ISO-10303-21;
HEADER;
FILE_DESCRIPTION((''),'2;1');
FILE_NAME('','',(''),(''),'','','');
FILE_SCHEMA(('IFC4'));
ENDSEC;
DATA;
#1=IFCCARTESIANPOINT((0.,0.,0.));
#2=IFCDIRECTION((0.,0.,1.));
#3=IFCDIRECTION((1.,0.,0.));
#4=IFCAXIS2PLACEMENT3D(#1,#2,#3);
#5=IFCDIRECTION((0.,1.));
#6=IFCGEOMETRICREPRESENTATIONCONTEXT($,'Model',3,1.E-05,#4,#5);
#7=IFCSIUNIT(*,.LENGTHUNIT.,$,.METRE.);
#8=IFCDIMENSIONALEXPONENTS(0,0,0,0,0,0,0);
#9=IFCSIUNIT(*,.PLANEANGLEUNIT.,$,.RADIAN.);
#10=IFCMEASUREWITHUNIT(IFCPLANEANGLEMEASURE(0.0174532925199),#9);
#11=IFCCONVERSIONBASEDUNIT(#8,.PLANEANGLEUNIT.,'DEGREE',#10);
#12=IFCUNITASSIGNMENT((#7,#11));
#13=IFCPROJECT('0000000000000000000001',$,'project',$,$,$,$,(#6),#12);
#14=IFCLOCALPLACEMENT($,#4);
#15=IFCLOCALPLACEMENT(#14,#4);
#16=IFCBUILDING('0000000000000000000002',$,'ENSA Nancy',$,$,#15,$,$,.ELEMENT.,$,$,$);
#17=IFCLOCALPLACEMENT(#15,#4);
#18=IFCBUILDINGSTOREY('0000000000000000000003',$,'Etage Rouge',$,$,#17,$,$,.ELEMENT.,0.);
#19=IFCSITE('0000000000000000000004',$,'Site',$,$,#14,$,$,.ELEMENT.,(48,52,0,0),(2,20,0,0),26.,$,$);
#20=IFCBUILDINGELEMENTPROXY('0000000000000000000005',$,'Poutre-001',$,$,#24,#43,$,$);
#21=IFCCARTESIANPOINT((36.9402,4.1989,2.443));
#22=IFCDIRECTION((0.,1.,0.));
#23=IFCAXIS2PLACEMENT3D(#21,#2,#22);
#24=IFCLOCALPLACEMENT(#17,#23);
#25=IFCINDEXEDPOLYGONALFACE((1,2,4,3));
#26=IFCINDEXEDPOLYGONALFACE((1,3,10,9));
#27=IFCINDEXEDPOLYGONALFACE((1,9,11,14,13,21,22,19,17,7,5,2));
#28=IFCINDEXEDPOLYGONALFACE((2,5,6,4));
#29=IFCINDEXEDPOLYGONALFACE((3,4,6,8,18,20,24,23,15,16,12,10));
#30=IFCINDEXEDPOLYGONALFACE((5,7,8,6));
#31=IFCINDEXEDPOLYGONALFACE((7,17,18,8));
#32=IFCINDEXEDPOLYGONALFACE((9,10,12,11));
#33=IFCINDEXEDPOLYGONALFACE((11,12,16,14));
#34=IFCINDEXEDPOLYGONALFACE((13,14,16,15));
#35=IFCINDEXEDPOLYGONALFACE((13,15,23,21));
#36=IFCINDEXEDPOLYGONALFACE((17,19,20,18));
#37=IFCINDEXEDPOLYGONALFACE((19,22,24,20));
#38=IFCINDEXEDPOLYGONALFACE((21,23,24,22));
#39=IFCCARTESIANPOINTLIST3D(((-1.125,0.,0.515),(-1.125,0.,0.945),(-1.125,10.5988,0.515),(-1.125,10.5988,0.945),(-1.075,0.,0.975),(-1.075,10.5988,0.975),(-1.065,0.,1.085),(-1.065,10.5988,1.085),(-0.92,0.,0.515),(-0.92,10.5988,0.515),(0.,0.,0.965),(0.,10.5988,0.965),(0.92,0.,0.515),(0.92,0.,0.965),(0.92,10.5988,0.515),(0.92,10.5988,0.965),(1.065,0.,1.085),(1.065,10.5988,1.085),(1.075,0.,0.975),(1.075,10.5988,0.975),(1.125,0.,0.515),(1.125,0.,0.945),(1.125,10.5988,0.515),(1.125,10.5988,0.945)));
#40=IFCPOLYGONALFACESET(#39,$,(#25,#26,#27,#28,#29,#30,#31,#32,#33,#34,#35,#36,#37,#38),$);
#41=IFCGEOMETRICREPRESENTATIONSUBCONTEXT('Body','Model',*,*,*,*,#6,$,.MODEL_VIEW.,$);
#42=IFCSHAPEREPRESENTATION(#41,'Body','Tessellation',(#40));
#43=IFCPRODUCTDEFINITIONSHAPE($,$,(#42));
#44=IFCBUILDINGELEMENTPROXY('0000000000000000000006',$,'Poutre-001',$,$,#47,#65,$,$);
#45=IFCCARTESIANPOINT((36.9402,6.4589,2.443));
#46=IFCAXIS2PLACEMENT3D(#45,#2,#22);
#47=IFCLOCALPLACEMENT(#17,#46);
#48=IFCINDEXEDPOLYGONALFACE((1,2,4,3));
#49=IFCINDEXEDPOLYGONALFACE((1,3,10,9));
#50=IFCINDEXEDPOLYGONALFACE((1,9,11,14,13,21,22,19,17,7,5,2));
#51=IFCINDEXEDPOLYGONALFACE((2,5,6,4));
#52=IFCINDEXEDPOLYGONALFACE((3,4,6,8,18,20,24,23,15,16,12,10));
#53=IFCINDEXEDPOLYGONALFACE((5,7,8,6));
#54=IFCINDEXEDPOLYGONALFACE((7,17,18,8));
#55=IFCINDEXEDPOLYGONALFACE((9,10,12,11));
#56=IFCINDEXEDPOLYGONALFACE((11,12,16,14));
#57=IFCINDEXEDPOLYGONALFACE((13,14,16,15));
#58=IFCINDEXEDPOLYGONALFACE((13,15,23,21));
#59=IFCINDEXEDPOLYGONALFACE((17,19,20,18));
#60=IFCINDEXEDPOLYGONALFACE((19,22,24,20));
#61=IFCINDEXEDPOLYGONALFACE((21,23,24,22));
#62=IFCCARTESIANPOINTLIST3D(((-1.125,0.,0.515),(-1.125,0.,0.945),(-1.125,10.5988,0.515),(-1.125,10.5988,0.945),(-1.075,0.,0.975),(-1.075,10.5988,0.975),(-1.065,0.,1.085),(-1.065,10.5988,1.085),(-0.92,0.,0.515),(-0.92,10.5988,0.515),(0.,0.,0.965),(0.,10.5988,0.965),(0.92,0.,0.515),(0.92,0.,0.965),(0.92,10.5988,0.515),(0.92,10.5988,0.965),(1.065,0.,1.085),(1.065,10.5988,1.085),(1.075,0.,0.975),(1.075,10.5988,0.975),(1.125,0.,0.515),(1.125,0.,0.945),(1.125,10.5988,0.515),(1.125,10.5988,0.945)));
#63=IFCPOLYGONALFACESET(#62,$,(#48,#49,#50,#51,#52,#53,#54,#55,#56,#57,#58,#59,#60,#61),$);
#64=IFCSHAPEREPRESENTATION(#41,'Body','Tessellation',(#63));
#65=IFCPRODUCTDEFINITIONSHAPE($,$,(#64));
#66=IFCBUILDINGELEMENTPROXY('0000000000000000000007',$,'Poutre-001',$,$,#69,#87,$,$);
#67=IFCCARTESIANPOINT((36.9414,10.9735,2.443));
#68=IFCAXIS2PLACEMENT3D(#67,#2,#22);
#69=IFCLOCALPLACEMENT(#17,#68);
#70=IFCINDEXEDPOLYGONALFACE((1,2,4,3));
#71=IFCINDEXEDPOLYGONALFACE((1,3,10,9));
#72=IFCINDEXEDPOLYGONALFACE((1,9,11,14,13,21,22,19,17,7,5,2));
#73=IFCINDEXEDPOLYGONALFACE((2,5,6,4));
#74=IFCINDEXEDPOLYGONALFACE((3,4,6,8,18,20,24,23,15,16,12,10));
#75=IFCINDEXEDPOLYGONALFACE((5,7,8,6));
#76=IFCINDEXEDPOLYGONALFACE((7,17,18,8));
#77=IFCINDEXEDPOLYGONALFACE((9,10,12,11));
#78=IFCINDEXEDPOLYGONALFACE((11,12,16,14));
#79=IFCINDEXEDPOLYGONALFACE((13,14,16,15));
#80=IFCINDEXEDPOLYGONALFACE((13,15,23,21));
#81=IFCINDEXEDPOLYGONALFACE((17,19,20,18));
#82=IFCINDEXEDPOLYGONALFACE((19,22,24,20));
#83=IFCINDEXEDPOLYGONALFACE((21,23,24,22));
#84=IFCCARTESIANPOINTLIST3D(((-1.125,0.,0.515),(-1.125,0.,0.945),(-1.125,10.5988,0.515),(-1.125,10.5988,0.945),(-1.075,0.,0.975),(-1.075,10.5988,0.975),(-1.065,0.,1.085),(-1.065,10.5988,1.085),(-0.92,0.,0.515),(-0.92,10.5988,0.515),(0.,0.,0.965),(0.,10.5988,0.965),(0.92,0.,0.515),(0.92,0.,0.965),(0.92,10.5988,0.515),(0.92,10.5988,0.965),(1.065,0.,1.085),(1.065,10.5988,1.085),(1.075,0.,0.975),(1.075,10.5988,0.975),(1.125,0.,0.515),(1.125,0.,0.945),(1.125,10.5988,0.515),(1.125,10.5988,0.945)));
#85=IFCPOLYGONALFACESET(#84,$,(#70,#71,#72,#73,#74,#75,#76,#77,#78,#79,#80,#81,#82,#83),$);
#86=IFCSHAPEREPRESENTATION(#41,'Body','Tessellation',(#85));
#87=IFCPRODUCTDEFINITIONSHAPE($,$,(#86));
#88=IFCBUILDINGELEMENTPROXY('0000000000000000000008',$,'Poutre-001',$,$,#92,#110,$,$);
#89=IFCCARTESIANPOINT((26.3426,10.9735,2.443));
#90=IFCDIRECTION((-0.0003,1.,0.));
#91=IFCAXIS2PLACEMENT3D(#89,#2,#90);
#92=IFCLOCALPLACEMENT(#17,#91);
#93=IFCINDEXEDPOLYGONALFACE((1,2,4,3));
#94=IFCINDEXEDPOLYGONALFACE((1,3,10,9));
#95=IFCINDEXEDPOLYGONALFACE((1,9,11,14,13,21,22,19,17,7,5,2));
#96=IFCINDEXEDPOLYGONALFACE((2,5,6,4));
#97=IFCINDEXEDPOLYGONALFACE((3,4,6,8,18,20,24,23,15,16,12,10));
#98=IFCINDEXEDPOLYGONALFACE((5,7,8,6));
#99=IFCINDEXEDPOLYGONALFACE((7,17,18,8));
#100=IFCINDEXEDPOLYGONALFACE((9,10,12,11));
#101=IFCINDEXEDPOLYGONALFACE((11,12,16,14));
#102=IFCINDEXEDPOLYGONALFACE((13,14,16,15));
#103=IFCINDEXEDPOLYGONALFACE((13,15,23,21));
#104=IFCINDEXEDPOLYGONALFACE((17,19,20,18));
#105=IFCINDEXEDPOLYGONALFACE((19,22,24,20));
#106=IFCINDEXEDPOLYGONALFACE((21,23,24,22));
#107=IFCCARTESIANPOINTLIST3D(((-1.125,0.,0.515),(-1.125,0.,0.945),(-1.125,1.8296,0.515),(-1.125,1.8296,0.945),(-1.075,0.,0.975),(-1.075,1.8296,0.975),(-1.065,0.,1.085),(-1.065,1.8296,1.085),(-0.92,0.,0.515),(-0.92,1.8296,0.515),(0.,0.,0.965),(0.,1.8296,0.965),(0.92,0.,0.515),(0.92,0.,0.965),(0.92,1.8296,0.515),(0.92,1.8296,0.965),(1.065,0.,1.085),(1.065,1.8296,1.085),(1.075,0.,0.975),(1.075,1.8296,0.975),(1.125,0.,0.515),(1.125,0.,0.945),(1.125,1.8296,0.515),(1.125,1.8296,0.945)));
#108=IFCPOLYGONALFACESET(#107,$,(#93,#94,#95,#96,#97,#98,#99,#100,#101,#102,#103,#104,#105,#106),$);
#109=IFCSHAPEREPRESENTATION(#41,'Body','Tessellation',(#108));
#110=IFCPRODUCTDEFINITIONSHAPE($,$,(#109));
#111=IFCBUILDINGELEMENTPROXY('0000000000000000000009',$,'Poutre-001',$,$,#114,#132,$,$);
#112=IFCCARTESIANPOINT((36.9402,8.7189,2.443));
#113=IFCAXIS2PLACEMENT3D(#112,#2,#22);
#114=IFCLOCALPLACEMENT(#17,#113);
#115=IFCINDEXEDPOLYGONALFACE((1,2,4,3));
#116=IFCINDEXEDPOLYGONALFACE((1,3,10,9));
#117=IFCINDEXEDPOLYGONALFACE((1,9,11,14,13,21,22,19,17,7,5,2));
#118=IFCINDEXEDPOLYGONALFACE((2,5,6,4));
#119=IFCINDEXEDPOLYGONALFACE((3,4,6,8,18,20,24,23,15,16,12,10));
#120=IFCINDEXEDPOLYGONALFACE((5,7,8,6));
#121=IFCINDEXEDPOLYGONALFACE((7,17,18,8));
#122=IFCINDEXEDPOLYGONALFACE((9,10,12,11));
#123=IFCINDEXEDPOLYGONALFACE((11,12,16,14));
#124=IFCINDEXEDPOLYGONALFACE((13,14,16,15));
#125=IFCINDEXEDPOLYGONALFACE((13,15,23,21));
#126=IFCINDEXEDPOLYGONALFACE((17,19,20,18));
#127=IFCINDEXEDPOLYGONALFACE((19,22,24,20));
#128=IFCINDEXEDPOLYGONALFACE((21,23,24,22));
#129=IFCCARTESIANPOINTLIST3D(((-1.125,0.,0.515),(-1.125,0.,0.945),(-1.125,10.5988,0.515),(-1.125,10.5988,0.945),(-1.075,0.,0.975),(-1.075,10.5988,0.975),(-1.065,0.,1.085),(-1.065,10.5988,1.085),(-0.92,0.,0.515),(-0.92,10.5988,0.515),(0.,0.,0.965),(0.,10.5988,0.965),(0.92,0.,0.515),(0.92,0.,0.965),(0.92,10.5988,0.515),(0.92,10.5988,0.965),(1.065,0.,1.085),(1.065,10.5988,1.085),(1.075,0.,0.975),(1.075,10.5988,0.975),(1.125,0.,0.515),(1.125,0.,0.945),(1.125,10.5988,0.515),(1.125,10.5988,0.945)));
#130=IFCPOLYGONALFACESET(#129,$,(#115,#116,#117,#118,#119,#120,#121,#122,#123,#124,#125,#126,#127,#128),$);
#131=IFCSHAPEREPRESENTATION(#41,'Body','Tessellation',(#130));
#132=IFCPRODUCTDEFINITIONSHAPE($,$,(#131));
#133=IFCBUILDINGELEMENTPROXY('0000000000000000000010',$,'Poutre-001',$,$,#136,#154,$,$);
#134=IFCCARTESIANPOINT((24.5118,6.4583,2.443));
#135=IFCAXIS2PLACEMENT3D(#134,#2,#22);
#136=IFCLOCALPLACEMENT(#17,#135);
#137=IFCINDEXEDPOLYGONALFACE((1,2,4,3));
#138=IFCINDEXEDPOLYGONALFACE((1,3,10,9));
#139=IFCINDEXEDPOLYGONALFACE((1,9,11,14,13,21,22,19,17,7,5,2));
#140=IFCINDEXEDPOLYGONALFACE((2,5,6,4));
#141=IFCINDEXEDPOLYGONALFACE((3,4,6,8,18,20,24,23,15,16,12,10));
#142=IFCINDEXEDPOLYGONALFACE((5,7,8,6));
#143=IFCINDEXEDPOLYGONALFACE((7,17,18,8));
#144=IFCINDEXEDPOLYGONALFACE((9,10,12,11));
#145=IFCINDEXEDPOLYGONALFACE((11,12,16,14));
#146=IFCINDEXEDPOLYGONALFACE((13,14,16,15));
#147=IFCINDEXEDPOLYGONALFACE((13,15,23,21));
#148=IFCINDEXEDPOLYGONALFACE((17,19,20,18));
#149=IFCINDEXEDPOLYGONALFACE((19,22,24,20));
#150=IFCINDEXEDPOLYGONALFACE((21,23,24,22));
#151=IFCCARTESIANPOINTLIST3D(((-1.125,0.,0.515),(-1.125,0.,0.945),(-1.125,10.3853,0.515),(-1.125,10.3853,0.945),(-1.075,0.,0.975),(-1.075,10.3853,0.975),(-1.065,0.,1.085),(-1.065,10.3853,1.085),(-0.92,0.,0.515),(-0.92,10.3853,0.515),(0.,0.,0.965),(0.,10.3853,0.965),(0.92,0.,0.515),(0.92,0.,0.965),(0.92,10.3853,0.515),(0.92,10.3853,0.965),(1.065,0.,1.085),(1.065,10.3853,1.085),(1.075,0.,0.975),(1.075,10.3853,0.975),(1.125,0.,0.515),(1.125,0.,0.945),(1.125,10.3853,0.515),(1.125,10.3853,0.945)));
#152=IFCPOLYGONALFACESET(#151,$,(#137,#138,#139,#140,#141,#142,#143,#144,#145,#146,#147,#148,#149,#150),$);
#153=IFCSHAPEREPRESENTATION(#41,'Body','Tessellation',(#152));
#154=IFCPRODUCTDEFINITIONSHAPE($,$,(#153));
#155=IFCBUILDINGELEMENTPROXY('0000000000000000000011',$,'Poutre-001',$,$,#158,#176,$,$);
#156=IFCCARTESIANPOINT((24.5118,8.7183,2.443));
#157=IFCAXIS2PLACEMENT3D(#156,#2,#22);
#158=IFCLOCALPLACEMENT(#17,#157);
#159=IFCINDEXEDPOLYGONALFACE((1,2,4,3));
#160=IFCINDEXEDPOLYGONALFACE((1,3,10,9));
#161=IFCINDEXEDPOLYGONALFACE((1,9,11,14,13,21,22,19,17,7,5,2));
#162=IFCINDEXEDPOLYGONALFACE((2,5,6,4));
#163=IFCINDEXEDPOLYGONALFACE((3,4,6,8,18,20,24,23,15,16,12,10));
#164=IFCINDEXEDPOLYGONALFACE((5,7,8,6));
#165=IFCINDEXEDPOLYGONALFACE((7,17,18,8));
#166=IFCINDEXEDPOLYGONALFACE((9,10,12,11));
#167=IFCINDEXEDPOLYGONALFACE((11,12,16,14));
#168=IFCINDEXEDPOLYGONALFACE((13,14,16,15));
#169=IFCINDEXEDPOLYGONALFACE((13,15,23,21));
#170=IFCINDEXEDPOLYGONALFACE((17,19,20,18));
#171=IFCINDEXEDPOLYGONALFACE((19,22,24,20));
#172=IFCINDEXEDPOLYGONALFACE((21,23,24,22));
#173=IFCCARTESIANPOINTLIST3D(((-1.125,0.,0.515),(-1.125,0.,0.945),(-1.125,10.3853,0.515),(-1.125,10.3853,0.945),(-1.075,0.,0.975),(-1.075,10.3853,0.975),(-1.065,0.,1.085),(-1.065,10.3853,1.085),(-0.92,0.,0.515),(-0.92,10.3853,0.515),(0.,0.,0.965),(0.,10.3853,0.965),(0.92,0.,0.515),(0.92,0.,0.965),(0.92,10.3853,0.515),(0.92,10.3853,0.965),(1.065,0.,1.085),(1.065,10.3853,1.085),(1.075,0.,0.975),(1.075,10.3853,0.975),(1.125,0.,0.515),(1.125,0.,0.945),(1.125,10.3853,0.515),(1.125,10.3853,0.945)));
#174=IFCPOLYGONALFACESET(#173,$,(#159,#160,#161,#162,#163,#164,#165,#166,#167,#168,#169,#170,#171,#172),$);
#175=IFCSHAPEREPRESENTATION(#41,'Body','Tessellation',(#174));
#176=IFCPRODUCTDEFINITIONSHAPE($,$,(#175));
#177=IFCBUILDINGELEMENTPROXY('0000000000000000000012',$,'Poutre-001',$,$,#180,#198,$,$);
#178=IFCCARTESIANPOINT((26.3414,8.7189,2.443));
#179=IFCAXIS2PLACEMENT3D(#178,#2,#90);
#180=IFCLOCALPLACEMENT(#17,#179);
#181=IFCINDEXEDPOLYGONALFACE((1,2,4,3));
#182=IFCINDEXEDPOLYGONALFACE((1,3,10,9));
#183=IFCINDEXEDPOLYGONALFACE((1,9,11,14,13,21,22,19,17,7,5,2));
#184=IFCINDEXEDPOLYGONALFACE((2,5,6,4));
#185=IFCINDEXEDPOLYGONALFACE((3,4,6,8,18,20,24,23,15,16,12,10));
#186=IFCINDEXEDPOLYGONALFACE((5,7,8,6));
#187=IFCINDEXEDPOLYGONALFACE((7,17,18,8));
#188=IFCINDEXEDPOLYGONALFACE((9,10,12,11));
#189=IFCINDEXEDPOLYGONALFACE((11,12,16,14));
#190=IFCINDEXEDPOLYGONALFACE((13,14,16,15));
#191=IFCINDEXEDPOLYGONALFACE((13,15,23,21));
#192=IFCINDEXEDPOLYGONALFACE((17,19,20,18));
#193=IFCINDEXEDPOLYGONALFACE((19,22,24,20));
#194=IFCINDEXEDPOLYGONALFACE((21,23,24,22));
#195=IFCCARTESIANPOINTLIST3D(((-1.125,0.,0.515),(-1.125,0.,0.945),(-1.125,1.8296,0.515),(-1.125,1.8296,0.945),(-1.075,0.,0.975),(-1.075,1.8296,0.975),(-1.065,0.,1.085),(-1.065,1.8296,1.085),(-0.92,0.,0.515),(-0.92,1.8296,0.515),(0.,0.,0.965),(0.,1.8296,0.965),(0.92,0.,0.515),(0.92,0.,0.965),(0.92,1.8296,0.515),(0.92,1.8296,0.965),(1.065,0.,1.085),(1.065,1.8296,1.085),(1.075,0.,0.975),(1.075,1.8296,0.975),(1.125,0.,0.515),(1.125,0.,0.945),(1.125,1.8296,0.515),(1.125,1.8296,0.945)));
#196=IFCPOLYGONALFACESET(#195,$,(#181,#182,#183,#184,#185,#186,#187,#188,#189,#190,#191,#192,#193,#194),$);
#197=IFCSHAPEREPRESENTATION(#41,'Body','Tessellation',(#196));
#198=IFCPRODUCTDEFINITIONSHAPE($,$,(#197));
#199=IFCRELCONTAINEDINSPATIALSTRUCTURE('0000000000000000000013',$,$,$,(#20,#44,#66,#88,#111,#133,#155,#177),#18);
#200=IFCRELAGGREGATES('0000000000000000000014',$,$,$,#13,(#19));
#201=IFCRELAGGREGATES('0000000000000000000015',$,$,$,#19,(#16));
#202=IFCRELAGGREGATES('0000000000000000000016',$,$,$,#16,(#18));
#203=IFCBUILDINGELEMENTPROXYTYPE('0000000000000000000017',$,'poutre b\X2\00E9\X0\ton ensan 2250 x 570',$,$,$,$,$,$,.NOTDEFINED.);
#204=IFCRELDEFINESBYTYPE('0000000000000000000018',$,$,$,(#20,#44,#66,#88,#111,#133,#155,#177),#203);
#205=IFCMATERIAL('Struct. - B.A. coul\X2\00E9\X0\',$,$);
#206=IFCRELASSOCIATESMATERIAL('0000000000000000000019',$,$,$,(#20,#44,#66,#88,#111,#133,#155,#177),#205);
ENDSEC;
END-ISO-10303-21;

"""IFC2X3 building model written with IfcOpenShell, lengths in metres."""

from ifc_helpers import new_model, entity, si_unit, converted_unit, direction, frame, origin_with_axes, place, context, subcontext, project, spatial, polyline, outline, extrude, material, type_object, element, save


model = new_model("IFC2X3")

# Units and contexts
model_context = context("Model", 3, precision=1e-05, world=origin_with_axes(), true_north=direction((0.0, 1.0)))
body_context = subcontext(model_context, "Body", "Model", "MODEL_VIEW")
ifc_project = project(units=[si_unit("LENGTHUNIT", "METRE"), converted_unit("PLANEANGLEUNIT", "DEGREE", entity("IfcPlaneAngleMeasure", 0.0174532925199), si_unit("PLANEANGLEUNIT", "RADIAN"), dimensions=[0, 0, 0, 0, 0, 0, 0])], contexts=[model_context])

# Site, building, storey
site_placement = place(None, origin_with_axes())
site = spatial("IfcSite", under=ifc_project, at=site_placement, Name="Site", CompositionType="ELEMENT", RefLatitude=(48, 52, 0, 0), RefLongitude=(2, 20, 0, 0), RefElevation=26.0)
building_placement = place(site_placement, origin_with_axes())
building = spatial("IfcBuilding", under=site, at=building_placement, Name="ENSA Nancy", CompositionType="ELEMENT")
storey_placement = place(building_placement, origin_with_axes())
storey = spatial("IfcBuildingStorey", under=building, at=storey_placement, Name="Etage Rouge", CompositionType="ELEMENT", Elevation=0.0)

# Building element proxies
ifc_material_1 = material(Name="Struct. - B.A. coulé")
building_element_proxy_type_1 = type_object("IfcBuildingElementProxyType", Name="poutre béton ensan 2250 x 570", PredefinedType="NOTDEFINED")
proxy_1_placement = place(storey_placement, frame((36.9402, 4.1989, 2.443), z_axis=(0.0, 0.0, 1.0), x_axis=(0.0, 1.0, 0.0)))
element("IfcBuildingElementProxy", 1, at=proxy_1_placement, inside=storey, type_object=building_element_proxy_type_1, material=ifc_material_1, Name="Poutre-001", context=body_context, shape_type="SweptSolid", body=[
    extrude(outline(polyline([(-1.065, 1.085), (-1.075, 0.975), (-1.125, 0.945), (-1.125, 0.515), (-0.92, 0.515), (0.0, 0.965), (0.92, 0.965), (0.92, 0.515), (1.125, 0.515), (1.125, 0.945), (1.075, 0.975), (1.065, 1.085), (-1.065, 1.085)])), frame((0.0, 10.5988, 0.0), z_axis=(0.0, -1.0, 0.0), x_axis=(1.0, 0.0, 0.0)), (0.0, 0.0, 1.0), 10.5988),
])
for number, where, z_axis, x_axis, name in (
    (2, (36.9402, 6.4589, 2.443), (0.0, 0.0, 1.0), (0.0, 1.0, 0.0), "Poutre-001"),
    (3, (36.9414, 10.9735, 2.443), (0.0, 0.0, 1.0), (0.0, 1.0, 0.0), "Poutre-001"),
):
    element("IfcBuildingElementProxy", number, at=place(storey_placement, frame(where, z_axis=z_axis, x_axis=x_axis)), inside=storey, type_object=building_element_proxy_type_1, material=ifc_material_1, Name=name, context=body_context, shape_type="SweptSolid", body=[
        extrude(outline(polyline([(-1.065, 1.085), (-1.075, 0.975), (-1.125, 0.945), (-1.125, 0.515), (-0.92, 0.515), (0.0, 0.965), (0.92, 0.965), (0.92, 0.515), (1.125, 0.515), (1.125, 0.945), (1.075, 0.975), (1.065, 1.085), (-1.065, 1.085)])), frame((0.0, 10.5988, 0.0), z_axis=(0.0, -1.0, 0.0), x_axis=(1.0, 0.0, 0.0)), (0.0, 0.0, 1.0), 10.5988),
    ])
proxy_2_placement = place(storey_placement, frame((26.3426, 10.9735, 2.443), z_axis=(0.0, 0.0, 1.0), x_axis=(-0.0003, 1.0, 0.0)))
element("IfcBuildingElementProxy", 4, at=proxy_2_placement, inside=storey, type_object=building_element_proxy_type_1, material=ifc_material_1, Name="Poutre-001", context=body_context, shape_type="SweptSolid", body=[
    extrude(outline(polyline([(-1.065, 1.085), (-1.075, 0.975), (-1.125, 0.945), (-1.125, 0.515), (-0.92, 0.515), (0.0, 0.965), (0.92, 0.965), (0.92, 0.515), (1.125, 0.515), (1.125, 0.945), (1.075, 0.975), (1.065, 1.085), (-1.065, 1.085)])), frame((0.0, 1.8296, 0.0), z_axis=(0.0, -1.0, 0.0), x_axis=(1.0, 0.0, 0.0)), (0.0, 0.0, 1.0), 1.8296),
])
proxy_3_placement = place(storey_placement, frame((36.9402, 8.7189, 2.443), z_axis=(0.0, 0.0, 1.0), x_axis=(0.0, 1.0, 0.0)))
element("IfcBuildingElementProxy", 5, at=proxy_3_placement, inside=storey, type_object=building_element_proxy_type_1, material=ifc_material_1, Name="Poutre-001", context=body_context, shape_type="SweptSolid", body=[
    extrude(outline(polyline([(-1.065, 1.085), (-1.075, 0.975), (-1.125, 0.945), (-1.125, 0.515), (-0.92, 0.515), (0.0, 0.965), (0.92, 0.965), (0.92, 0.515), (1.125, 0.515), (1.125, 0.945), (1.075, 0.975), (1.065, 1.085), (-1.065, 1.085)])), frame((0.0, 10.5988, 0.0), z_axis=(0.0, -1.0, 0.0), x_axis=(1.0, 0.0, 0.0)), (0.0, 0.0, 1.0), 10.5988),
])
for number, where, z_axis, x_axis, name in (
    (6, (24.5118, 6.4583, 2.443), (0.0, 0.0, 1.0), (0.0, 1.0, 0.0), "Poutre-001"),
    (7, (24.5118, 8.7183, 2.443), (0.0, 0.0, 1.0), (0.0, 1.0, 0.0), "Poutre-001"),
):
    element("IfcBuildingElementProxy", number, at=place(storey_placement, frame(where, z_axis=z_axis, x_axis=x_axis)), inside=storey, type_object=building_element_proxy_type_1, material=ifc_material_1, Name=name, context=body_context, shape_type="SweptSolid", body=[
        extrude(outline(polyline([(-1.065, 1.085), (-1.075, 0.975), (-1.125, 0.945), (-1.125, 0.515), (-0.92, 0.515), (0.0, 0.965), (0.92, 0.965), (0.92, 0.515), (1.125, 0.515), (1.125, 0.945), (1.075, 0.975), (1.065, 1.085), (-1.065, 1.085)])), frame((0.0, 10.3853, 0.0), z_axis=(0.0, -1.0, 0.0), x_axis=(1.0, 0.0, 0.0)), (0.0, 0.0, 1.0), 10.3853),
    ])
for number, where, z_axis, x_axis, name in (
    (8, (26.3414, 8.7189, 2.443), (0.0, 0.0, 1.0), (-0.0003, 1.0, 0.0), "Poutre-001"),
):
    element("IfcBuildingElementProxy", number, at=place(storey_placement, frame(where, z_axis=z_axis, x_axis=x_axis)), inside=storey, type_object=building_element_proxy_type_1, material=ifc_material_1, Name=name, context=body_context, shape_type="SweptSolid", body=[
        extrude(outline(polyline([(-1.065, 1.085), (-1.075, 0.975), (-1.125, 0.945), (-1.125, 0.515), (-0.92, 0.515), (0.0, 0.965), (0.92, 0.965), (0.92, 0.515), (1.125, 0.515), (1.125, 0.945), (1.075, 0.975), (1.065, 1.085), (-1.065, 1.085)])), frame((0.0, 1.8296, 0.0), z_axis=(0.0, -1.0, 0.0), x_axis=(1.0, 0.0, 0.0)), (0.0, 0.0, 1.0), 1.8296),
    ])

save(model, "model.ifc")
